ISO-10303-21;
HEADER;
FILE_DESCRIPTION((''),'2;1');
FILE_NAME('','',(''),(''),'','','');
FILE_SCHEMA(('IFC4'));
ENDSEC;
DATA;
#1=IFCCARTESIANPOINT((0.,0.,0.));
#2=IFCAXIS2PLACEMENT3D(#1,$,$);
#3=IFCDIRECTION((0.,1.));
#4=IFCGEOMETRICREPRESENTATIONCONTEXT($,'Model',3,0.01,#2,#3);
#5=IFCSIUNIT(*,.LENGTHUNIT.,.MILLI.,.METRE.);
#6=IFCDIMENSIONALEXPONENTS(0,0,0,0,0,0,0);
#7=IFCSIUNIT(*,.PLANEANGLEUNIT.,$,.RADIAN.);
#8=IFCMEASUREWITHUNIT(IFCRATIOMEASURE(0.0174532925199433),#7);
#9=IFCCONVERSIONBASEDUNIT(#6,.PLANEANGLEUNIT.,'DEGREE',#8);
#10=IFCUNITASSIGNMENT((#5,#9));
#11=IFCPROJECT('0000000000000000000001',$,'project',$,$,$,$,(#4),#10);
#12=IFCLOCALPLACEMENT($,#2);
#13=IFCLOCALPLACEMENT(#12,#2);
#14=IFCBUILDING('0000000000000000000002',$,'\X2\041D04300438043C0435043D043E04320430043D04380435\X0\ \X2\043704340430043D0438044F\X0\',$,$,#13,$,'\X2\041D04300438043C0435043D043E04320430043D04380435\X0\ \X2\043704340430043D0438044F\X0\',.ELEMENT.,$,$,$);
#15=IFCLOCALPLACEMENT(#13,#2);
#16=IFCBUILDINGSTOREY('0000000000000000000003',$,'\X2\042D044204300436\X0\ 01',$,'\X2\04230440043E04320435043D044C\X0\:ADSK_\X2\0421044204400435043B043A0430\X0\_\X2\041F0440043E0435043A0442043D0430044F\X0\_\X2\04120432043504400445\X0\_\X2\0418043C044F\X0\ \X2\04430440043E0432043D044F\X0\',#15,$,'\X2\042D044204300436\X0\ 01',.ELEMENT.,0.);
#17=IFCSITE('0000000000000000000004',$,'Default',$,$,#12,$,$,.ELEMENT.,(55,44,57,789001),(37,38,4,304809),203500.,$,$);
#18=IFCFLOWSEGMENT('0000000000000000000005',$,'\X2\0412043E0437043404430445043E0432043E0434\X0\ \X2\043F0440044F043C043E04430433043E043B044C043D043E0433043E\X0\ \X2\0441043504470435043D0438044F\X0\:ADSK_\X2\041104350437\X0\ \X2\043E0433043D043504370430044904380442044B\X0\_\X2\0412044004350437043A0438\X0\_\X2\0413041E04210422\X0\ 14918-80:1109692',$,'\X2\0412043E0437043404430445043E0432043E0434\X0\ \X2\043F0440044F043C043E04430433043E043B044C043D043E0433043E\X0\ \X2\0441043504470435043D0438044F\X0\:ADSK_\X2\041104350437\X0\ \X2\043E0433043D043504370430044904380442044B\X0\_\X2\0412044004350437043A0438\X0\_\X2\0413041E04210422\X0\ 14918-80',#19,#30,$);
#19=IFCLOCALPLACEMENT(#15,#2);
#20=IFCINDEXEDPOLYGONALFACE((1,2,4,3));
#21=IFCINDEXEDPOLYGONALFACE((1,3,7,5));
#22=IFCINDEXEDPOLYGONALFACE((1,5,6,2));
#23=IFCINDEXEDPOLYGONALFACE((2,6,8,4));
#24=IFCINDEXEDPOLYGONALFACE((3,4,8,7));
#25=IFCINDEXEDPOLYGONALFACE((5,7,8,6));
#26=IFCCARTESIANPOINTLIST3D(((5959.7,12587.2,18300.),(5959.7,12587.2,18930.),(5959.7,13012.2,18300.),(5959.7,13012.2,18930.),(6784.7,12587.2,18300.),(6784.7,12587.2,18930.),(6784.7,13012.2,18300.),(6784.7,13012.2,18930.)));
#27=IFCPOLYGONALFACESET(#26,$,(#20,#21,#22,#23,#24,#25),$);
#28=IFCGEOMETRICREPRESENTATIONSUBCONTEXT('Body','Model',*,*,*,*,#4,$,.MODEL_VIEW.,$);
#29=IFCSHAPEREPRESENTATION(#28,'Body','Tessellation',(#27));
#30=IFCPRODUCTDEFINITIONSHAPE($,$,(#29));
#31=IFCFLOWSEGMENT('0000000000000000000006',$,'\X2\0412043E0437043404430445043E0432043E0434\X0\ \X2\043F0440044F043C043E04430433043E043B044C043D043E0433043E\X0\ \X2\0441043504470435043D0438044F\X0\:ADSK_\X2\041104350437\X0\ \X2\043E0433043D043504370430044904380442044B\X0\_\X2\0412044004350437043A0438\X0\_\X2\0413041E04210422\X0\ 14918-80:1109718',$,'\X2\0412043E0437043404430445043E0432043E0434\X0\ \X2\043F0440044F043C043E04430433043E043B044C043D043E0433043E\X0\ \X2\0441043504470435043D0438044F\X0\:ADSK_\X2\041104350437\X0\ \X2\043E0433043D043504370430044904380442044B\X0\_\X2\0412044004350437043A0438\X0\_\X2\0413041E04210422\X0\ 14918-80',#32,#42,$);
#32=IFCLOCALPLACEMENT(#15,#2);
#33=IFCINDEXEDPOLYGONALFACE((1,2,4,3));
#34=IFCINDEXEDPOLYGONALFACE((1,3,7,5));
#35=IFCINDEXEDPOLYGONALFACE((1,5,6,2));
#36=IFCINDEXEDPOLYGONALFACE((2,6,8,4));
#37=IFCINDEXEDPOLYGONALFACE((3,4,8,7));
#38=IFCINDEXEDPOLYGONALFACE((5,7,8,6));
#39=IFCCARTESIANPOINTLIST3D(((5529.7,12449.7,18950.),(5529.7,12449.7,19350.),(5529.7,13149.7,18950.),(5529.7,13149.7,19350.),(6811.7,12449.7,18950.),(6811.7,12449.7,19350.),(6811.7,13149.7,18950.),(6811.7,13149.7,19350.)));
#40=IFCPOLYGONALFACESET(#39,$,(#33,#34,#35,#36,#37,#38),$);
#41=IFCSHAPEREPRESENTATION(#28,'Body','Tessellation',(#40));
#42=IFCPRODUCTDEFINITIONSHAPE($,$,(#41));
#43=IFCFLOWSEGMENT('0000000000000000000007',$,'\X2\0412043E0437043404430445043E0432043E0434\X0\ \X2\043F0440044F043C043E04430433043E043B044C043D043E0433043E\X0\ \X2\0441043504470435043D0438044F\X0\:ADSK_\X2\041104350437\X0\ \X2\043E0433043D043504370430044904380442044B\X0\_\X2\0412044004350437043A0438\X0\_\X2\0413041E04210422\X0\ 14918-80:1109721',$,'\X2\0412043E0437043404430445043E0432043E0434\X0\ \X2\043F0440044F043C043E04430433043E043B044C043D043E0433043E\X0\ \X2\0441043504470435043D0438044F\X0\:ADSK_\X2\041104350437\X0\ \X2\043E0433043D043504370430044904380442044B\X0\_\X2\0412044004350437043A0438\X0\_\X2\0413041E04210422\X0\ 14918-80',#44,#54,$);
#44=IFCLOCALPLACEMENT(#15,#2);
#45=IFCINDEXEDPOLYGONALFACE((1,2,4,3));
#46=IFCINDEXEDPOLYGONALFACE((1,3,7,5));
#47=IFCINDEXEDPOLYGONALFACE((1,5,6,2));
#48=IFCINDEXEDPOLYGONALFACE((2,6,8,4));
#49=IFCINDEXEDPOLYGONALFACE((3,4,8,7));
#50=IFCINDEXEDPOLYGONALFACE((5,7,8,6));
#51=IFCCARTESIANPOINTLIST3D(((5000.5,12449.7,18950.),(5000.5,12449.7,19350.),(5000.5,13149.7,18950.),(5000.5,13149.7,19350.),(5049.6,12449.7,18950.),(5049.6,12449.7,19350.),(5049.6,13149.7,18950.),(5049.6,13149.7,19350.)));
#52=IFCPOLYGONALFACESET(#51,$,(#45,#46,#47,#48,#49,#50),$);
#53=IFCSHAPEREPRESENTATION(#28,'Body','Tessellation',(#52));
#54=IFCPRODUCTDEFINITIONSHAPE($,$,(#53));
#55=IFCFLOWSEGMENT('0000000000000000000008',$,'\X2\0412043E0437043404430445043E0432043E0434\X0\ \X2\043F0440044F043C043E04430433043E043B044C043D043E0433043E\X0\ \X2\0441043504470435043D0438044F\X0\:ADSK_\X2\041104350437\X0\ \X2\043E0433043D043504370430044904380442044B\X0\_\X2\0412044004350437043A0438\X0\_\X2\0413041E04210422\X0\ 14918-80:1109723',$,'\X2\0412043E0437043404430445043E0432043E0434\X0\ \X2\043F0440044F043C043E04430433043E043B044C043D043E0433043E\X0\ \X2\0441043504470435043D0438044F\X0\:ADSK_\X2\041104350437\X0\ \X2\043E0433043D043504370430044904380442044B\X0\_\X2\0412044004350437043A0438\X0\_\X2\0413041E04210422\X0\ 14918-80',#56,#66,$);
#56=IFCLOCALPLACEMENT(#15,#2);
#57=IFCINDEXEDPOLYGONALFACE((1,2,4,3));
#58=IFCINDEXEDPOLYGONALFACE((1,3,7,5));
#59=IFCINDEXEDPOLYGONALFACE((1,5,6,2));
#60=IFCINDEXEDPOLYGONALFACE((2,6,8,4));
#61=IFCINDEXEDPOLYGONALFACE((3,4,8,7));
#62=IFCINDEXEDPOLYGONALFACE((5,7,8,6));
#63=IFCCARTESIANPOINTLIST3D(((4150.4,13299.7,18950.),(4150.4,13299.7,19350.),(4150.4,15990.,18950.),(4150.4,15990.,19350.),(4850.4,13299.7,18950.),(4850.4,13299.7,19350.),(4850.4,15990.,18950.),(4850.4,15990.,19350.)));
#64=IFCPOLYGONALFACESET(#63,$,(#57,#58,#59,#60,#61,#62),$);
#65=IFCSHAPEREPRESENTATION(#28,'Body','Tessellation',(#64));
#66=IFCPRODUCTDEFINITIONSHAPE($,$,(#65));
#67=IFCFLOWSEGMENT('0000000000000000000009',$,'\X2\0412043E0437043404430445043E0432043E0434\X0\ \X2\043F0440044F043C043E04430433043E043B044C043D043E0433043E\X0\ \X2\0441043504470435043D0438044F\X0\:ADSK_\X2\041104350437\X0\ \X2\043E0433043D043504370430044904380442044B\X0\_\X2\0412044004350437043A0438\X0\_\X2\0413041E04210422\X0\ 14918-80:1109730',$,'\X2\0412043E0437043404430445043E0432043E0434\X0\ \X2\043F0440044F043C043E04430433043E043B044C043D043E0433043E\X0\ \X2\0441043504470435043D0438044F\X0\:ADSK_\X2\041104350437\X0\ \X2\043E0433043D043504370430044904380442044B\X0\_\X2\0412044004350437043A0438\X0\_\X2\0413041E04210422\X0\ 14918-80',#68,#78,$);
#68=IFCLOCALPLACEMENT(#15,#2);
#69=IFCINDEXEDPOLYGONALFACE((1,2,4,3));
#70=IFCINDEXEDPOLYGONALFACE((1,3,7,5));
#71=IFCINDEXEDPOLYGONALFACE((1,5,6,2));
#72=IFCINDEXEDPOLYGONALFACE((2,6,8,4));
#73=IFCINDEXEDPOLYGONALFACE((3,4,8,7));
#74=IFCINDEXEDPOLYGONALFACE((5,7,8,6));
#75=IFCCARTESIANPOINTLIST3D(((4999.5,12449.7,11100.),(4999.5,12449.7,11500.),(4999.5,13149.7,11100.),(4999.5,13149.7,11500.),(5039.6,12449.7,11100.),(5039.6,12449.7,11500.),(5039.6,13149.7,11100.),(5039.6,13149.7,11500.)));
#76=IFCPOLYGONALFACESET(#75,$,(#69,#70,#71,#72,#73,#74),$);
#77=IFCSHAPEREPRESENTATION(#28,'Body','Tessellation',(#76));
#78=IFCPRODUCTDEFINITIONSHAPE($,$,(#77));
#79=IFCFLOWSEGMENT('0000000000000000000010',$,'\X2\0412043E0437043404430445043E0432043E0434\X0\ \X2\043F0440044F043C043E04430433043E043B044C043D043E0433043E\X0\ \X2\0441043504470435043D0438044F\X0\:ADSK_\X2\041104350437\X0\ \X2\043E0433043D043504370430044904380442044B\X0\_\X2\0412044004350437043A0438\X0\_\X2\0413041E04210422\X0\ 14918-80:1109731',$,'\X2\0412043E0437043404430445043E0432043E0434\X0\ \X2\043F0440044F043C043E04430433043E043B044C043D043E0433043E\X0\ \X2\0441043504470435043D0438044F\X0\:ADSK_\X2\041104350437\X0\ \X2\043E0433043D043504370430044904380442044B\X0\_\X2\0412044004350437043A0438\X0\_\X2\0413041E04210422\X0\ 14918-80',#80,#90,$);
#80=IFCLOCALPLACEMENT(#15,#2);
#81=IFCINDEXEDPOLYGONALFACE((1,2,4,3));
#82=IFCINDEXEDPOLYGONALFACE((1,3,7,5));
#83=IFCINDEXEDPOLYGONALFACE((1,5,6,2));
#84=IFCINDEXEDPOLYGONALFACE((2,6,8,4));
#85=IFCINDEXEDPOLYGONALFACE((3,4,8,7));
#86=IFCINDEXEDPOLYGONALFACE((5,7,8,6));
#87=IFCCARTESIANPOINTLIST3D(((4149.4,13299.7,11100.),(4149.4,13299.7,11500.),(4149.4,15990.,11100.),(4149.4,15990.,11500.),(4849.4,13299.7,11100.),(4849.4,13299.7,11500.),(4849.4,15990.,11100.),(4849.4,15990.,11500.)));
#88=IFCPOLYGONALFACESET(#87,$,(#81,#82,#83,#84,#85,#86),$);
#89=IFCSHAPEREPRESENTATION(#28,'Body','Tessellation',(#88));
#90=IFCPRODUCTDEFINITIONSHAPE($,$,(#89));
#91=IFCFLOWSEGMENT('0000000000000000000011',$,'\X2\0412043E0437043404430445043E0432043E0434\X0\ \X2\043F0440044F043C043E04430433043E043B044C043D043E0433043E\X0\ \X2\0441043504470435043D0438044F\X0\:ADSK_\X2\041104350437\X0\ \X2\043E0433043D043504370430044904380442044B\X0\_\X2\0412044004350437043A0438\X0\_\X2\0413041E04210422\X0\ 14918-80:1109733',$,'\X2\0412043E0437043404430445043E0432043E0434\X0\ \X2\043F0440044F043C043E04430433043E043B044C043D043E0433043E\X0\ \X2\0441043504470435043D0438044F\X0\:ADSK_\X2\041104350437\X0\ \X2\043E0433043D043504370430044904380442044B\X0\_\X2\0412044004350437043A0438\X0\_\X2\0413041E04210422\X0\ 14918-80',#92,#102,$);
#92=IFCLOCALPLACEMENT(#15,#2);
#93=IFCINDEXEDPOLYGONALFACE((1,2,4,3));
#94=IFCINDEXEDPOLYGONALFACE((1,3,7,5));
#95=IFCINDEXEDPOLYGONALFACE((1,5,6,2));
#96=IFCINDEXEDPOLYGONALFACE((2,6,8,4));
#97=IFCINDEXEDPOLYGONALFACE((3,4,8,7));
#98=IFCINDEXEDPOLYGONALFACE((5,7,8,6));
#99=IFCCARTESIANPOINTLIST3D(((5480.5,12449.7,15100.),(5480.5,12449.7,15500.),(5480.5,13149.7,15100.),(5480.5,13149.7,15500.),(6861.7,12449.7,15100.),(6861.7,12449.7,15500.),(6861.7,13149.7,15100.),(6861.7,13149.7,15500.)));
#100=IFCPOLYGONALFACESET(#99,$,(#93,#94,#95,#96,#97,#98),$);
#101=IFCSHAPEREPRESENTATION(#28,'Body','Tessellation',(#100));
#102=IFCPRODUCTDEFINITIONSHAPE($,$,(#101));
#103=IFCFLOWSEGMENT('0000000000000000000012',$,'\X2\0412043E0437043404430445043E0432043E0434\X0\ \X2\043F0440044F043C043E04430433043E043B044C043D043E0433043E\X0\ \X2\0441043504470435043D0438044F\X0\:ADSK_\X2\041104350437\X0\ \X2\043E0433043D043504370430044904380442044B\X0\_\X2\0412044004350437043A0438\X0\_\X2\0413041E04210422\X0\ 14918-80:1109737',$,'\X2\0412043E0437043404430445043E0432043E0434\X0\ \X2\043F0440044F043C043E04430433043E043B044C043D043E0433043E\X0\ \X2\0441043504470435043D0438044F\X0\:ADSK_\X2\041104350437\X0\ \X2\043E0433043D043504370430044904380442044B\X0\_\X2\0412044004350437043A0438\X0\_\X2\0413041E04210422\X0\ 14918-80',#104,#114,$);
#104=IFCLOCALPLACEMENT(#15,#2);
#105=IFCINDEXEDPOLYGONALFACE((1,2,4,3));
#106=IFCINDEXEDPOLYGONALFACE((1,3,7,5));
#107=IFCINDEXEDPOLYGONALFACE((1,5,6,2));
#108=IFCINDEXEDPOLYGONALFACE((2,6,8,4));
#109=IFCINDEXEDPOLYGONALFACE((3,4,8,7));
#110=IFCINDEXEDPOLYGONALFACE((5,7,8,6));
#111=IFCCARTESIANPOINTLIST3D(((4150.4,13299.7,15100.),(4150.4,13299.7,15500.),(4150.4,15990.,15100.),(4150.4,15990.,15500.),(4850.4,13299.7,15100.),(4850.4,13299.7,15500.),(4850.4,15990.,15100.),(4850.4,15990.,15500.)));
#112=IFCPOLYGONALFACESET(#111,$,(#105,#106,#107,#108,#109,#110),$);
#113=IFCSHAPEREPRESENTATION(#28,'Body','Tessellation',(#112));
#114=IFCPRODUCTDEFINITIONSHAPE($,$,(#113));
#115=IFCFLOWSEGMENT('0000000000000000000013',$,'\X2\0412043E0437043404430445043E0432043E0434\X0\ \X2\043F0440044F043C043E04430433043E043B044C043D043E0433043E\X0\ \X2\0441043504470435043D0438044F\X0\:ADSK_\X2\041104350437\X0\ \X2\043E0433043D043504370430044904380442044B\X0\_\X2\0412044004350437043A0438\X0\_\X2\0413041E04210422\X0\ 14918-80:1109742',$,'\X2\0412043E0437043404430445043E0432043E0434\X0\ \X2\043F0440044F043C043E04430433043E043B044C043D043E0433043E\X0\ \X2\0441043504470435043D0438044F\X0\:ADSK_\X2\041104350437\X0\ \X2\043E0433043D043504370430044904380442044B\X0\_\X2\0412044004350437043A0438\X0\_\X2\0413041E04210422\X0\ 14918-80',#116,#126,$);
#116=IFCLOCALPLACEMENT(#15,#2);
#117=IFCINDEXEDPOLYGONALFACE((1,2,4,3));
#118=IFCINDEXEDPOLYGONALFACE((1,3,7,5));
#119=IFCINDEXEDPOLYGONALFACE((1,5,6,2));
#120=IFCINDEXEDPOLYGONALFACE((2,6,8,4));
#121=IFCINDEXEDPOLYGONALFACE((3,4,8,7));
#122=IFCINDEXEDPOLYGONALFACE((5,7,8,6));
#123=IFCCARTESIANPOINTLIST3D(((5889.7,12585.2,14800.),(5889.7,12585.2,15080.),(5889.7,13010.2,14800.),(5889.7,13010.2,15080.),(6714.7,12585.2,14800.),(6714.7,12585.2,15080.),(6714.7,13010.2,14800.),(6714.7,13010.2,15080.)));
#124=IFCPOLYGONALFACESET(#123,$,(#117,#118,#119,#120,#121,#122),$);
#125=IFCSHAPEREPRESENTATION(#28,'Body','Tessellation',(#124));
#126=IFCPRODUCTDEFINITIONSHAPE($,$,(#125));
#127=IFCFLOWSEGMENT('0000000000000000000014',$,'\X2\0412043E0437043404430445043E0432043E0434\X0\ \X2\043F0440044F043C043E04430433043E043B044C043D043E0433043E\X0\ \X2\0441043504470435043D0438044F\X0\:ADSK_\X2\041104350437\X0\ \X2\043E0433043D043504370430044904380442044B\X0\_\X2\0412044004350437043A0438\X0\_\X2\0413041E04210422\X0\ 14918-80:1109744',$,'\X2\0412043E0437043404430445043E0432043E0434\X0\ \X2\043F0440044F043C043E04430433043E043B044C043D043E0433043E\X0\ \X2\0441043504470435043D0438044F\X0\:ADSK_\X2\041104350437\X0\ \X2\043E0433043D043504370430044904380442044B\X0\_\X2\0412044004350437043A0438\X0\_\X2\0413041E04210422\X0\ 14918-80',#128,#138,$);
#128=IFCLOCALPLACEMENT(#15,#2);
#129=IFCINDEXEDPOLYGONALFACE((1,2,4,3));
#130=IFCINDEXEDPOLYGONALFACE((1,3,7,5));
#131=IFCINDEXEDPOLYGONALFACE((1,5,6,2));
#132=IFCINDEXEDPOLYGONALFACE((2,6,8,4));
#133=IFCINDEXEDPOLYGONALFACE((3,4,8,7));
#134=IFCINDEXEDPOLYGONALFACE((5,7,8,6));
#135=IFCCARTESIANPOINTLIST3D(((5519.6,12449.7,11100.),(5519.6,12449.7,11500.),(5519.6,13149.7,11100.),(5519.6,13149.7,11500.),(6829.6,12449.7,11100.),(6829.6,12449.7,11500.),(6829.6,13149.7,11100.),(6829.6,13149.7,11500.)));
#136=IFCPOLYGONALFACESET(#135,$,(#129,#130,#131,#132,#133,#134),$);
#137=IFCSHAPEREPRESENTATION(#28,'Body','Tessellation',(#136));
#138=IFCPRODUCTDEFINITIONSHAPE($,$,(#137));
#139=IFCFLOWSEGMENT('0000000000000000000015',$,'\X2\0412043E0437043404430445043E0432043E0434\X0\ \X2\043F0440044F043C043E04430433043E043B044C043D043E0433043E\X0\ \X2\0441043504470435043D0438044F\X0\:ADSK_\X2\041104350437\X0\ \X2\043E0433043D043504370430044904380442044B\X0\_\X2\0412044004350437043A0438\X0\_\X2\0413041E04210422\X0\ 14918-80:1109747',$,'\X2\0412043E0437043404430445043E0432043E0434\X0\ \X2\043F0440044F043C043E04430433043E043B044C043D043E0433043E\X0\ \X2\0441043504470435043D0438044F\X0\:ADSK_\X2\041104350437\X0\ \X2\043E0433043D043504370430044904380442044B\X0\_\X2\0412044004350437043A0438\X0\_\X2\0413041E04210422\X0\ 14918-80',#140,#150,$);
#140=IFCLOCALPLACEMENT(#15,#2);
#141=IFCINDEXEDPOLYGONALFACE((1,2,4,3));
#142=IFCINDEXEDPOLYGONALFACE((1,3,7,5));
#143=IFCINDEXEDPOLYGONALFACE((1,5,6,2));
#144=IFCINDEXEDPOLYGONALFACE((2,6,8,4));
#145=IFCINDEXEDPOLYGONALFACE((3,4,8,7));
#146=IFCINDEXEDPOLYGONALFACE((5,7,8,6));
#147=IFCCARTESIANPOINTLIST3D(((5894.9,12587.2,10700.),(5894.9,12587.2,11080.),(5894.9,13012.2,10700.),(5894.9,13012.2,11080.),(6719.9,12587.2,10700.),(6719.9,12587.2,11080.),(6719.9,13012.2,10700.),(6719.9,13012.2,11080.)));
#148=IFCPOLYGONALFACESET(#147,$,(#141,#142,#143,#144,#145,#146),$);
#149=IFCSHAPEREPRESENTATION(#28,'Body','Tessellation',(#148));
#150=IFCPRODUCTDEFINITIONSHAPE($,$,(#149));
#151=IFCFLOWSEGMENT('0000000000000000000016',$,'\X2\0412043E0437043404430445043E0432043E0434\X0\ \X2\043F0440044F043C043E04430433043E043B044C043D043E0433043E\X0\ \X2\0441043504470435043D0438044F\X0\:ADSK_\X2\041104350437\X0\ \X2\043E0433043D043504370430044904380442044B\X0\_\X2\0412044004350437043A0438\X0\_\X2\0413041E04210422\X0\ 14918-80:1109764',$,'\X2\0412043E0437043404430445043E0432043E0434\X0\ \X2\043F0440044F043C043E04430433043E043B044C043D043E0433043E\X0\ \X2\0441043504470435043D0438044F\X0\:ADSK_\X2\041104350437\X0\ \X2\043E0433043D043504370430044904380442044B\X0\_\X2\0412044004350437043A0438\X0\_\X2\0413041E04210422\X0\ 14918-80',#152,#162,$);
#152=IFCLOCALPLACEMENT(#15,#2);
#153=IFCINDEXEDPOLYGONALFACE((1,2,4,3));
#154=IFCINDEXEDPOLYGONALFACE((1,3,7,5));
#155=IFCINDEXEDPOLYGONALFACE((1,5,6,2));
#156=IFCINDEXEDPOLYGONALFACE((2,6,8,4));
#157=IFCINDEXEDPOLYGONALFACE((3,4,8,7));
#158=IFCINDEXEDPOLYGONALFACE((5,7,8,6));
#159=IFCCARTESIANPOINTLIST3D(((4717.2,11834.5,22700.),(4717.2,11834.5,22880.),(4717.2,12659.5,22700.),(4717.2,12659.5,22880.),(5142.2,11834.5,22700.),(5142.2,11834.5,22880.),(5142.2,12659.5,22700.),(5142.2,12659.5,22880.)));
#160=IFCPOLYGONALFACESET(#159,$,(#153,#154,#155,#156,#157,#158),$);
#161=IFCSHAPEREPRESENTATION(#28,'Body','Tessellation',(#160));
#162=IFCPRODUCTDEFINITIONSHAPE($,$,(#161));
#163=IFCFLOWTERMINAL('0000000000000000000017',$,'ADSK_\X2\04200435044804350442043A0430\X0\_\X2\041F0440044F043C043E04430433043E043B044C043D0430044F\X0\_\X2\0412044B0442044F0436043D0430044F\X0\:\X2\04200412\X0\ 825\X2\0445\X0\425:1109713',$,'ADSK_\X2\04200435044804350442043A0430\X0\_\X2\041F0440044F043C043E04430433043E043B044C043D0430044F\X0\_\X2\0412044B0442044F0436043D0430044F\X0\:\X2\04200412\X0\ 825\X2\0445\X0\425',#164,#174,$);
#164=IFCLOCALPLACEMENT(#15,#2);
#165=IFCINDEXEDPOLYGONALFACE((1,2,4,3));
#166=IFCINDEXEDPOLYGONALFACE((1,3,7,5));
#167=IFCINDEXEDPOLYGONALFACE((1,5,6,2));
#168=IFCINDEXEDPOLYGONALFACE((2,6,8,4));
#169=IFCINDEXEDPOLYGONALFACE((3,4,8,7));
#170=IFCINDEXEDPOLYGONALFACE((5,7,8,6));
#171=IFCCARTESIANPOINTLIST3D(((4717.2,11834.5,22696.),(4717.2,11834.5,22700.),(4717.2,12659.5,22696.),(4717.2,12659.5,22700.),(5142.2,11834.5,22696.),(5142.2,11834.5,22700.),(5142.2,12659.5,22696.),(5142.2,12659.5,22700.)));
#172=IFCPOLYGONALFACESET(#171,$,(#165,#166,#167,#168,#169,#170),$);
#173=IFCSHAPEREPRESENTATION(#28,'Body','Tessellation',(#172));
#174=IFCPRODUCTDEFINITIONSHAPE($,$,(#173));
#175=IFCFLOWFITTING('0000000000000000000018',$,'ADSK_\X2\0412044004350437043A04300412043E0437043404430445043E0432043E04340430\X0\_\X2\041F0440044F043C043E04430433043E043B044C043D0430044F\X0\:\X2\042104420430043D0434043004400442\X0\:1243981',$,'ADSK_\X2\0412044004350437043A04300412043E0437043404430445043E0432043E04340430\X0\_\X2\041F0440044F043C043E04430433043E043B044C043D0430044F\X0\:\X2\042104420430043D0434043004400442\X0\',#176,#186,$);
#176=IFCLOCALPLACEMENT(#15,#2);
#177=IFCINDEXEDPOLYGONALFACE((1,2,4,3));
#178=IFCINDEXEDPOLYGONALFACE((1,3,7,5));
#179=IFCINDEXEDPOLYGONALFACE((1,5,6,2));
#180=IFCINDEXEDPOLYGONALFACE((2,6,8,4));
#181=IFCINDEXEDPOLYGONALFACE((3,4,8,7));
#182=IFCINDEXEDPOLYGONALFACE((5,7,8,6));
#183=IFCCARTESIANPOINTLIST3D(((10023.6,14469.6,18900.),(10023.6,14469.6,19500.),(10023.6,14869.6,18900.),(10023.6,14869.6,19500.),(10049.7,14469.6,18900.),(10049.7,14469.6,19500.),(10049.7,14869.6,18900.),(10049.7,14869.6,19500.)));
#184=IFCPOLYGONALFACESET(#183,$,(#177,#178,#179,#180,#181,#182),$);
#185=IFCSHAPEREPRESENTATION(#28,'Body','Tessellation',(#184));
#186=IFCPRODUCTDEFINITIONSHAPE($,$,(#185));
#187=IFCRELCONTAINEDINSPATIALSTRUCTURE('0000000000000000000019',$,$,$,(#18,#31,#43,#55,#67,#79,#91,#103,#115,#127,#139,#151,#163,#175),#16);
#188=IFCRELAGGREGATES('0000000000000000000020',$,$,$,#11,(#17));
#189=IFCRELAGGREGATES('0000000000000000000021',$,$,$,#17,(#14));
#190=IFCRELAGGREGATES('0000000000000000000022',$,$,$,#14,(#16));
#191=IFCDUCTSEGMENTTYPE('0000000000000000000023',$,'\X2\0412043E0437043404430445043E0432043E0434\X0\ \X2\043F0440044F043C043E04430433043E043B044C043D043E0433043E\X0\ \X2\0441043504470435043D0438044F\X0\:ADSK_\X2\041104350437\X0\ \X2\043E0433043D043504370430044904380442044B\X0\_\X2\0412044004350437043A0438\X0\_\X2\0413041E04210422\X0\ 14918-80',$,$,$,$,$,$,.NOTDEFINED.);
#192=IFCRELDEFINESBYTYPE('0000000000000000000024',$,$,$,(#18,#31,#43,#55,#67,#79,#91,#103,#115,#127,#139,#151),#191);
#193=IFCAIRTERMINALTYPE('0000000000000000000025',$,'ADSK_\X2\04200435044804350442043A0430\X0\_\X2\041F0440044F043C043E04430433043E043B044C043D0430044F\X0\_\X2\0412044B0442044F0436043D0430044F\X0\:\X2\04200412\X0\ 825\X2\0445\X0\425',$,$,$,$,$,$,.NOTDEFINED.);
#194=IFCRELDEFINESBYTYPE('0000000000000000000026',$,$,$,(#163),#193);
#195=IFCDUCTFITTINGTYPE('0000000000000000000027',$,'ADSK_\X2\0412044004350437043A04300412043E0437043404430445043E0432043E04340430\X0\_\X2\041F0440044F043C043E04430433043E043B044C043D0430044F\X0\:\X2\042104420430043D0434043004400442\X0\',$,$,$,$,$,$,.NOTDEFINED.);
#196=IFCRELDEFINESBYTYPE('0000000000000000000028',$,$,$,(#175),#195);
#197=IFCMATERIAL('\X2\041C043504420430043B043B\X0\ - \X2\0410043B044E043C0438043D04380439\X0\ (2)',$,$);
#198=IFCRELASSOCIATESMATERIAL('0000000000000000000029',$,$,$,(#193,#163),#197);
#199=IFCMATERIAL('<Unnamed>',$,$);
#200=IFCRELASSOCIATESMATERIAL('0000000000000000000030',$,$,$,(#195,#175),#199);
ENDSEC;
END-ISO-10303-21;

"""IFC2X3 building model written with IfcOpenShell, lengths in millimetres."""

from ifc_helpers import new_model, entity, si_unit, converted_unit, direction, frame, origin, origin_2d_with_axis, place, context, subcontext, project, spatial, rectangle, extrude, source, transform, mapped, material, type_object, type_shapes, element, save


model = new_model("IFC2X3")

# Units and contexts
model_context = context("Model", 3, precision=0.01, world=origin(), true_north=direction((0.0, 1.0)))
body_context = subcontext(model_context, "Body", "Model", "MODEL_VIEW")
ifc_project = project(units=[si_unit("LENGTHUNIT", "METRE", prefix="MILLI"), converted_unit("PLANEANGLEUNIT", "DEGREE", entity("IfcRatioMeasure", 0.0174532925199433), si_unit("PLANEANGLEUNIT", "RADIAN"), dimensions=[0, 0, 0, 0, 0, 0, 0])], contexts=[model_context])

# Site, building, storey
site_placement = place(None, origin())
site = spatial("IfcSite", under=ifc_project, at=site_placement, Name="Default", CompositionType="ELEMENT", RefLatitude=(55, 44, 57, 789001), RefLongitude=(37, 38, 4, 304809), RefElevation=203500.0)
building_placement = place(site_placement, origin())
building = spatial("IfcBuilding", under=site, at=building_placement, Name="Наименование здания", LongName="Наименование здания", CompositionType="ELEMENT")
storey_placement = place(building_placement, origin())
storey = spatial("IfcBuildingStorey", under=building, at=storey_placement, Name="Этаж 01", ObjectType="Уровень:ADSK_Стрелка_Проектная_Вверх_Имя уровня", LongName="Этаж 01", CompositionType="ELEMENT", Elevation=0.0)

# Flow segments
duct_segment_type_1 = type_object("IfcDuctSegmentType", Name="Воздуховод прямоугольного сечения:ADSK_Без огнезащиты_Врезки_ГОСТ 14918-80", PredefinedType="NOTDEFINED")
flow_segment_1_placement = place(storey_placement, frame((5959.7, 12587.2, 18300.0)))
element("IfcFlowSegment", 1, at=flow_segment_1_placement, inside=storey, type_object=duct_segment_type_1, Name="Воздуховод прямоугольного сечения:ADSK_Без огнезащиты_Врезки_ГОСТ 14918-80:1109692", ObjectType="Воздуховод прямоугольного сечения:ADSK_Без огнезащиты_Врезки_ГОСТ 14918-80", context=body_context, shape_type="SweptSolid", body=[
    extrude(rectangle(XDim=825.0, YDim=425.0, at=origin_2d_with_axis()), frame((412.5, 212.5, 0.0), z_axis=(0.0, 0.0, 1.0), x_axis=(-1.0, 0.0, 0.0)), (0.0, 0.0, 1.0), 630.0),
])
flow_segment_2_placement = place(storey_placement, frame((5529.6, 12449.7, 18950.0)))
element("IfcFlowSegment", 2, at=flow_segment_2_placement, inside=storey, type_object=duct_segment_type_1, Name="Воздуховод прямоугольного сечения:ADSK_Без огнезащиты_Врезки_ГОСТ 14918-80:1109718", ObjectType="Воздуховод прямоугольного сечения:ADSK_Без огнезащиты_Врезки_ГОСТ 14918-80", context=body_context, shape_type="SweptSolid", body=[
    extrude(rectangle(XDim=1282.1, YDim=700.0, at=origin_2d_with_axis()), frame((641.0, 350.0, 0.0)), (0.0, 0.0, 1.0), 400.0),
])
flow_segment_3_placement = place(storey_placement, frame((5000.4, 12449.7, 18950.0)))
element("IfcFlowSegment", 3, at=flow_segment_3_placement, inside=storey, type_object=duct_segment_type_1, Name="Воздуховод прямоугольного сечения:ADSK_Без огнезащиты_Врезки_ГОСТ 14918-80:1109721", ObjectType="Воздуховод прямоугольного сечения:ADSK_Без огнезащиты_Врезки_ГОСТ 14918-80", context=body_context, shape_type="SweptSolid", body=[
    extrude(rectangle(XDim=49.2, YDim=700.0, at=origin_2d_with_axis()), frame((24.6, 350.0, 0.0)), (0.0, 0.0, 1.0), 400.0),
])
flow_segment_4_placement = place(storey_placement, frame((4150.4, 13299.7, 18950.0)))
element("IfcFlowSegment", 4, at=flow_segment_4_placement, inside=storey, type_object=duct_segment_type_1, Name="Воздуховод прямоугольного сечения:ADSK_Без огнезащиты_Врезки_ГОСТ 14918-80:1109723", ObjectType="Воздуховод прямоугольного сечения:ADSK_Без огнезащиты_Врезки_ГОСТ 14918-80", context=body_context, shape_type="SweptSolid", body=[
    extrude(rectangle(XDim=2690.3, YDim=700.0, at=origin_2d_with_axis()), frame((350.0, 1345.2, 0.0), z_axis=(0.0, 0.0, 1.0), x_axis=(0.0, 1.0, 0.0)), (0.0, 0.0, 1.0), 400.0),
])
flow_segment_5_placement = place(storey_placement, frame((4999.4, 12449.7, 11100.0)))
element("IfcFlowSegment", 5, at=flow_segment_5_placement, inside=storey, type_object=duct_segment_type_1, Name="Воздуховод прямоугольного сечения:ADSK_Без огнезащиты_Врезки_ГОСТ 14918-80:1109730", ObjectType="Воздуховод прямоугольного сечения:ADSK_Без огнезащиты_Врезки_ГОСТ 14918-80", context=body_context, shape_type="SweptSolid", body=[
    extrude(rectangle(XDim=40.2, YDim=700.0, at=origin_2d_with_axis()), frame((20.1, 350.0, 0.0)), (0.0, 0.0, 1.0), 400.0),
])
flow_segment_6_placement = place(storey_placement, frame((4149.4, 13299.7, 11100.0)))
element("IfcFlowSegment", 6, at=flow_segment_6_placement, inside=storey, type_object=duct_segment_type_1, Name="Воздуховод прямоугольного сечения:ADSK_Без огнезащиты_Врезки_ГОСТ 14918-80:1109731", ObjectType="Воздуховод прямоугольного сечения:ADSK_Без огнезащиты_Врезки_ГОСТ 14918-80", context=body_context, shape_type="SweptSolid", body=[
    extrude(rectangle(XDim=2690.3, YDim=700.0, at=origin_2d_with_axis()), frame((350.0, 1345.2, 0.0), z_axis=(0.0, 0.0, 1.0), x_axis=(0.0, 1.0, 0.0)), (0.0, 0.0, 1.0), 400.0),
])
flow_segment_7_placement = place(storey_placement, frame((5480.4, 12449.7, 15100.0)))
element("IfcFlowSegment", 7, at=flow_segment_7_placement, inside=storey, type_object=duct_segment_type_1, Name="Воздуховод прямоугольного сечения:ADSK_Без огнезащиты_Врезки_ГОСТ 14918-80:1109733", ObjectType="Воздуховод прямоугольного сечения:ADSK_Без огнезащиты_Врезки_ГОСТ 14918-80", context=body_context, shape_type="SweptSolid", body=[
    extrude(rectangle(XDim=1381.3, YDim=700.0, at=origin_2d_with_axis()), frame((690.6, 350.0, 0.0)), (0.0, 0.0, 1.0), 400.0),
])
flow_segment_8_placement = place(storey_placement, frame((4150.4, 13299.7, 15100.0)))
element("IfcFlowSegment", 8, at=flow_segment_8_placement, inside=storey, type_object=duct_segment_type_1, Name="Воздуховод прямоугольного сечения:ADSK_Без огнезащиты_Врезки_ГОСТ 14918-80:1109737", ObjectType="Воздуховод прямоугольного сечения:ADSK_Без огнезащиты_Врезки_ГОСТ 14918-80", context=body_context, shape_type="SweptSolid", body=[
    extrude(rectangle(XDim=2690.3, YDim=700.0, at=origin_2d_with_axis()), frame((350.0, 1345.2, 0.0), z_axis=(0.0, 0.0, 1.0), x_axis=(0.0, 1.0, 0.0)), (0.0, 0.0, 1.0), 400.0),
])
flow_segment_9_placement = place(storey_placement, frame((5889.7, 12585.2, 14800.0)))
element("IfcFlowSegment", 9, at=flow_segment_9_placement, inside=storey, type_object=duct_segment_type_1, Name="Воздуховод прямоугольного сечения:ADSK_Без огнезащиты_Врезки_ГОСТ 14918-80:1109742", ObjectType="Воздуховод прямоугольного сечения:ADSK_Без огнезащиты_Врезки_ГОСТ 14918-80", context=body_context, shape_type="SweptSolid", body=[
    extrude(rectangle(XDim=825.0, YDim=425.0, at=origin_2d_with_axis()), frame((412.5, 212.5, 0.0)), (0.0, 0.0, 1.0), 280.0),
])
flow_segment_10_placement = place(storey_placement, frame((5519.6, 12449.7, 11100.0)))
element("IfcFlowSegment", 10, at=flow_segment_10_placement, inside=storey, type_object=duct_segment_type_1, Name="Воздуховод прямоугольного сечения:ADSK_Без огнезащиты_Врезки_ГОСТ 14918-80:1109744", ObjectType="Воздуховод прямоугольного сечения:ADSK_Без огнезащиты_Врезки_ГОСТ 14918-80", context=body_context, shape_type="SweptSolid", body=[
    extrude(rectangle(XDim=1310.0, YDim=700.0, at=origin_2d_with_axis()), frame((655.0, 350.0, 0.0)), (0.0, 0.0, 1.0), 400.0),
])
flow_segment_11_placement = place(storey_placement, frame((5894.9, 12587.2, 10700.0)))
element("IfcFlowSegment", 11, at=flow_segment_11_placement, inside=storey, type_object=duct_segment_type_1, Name="Воздуховод прямоугольного сечения:ADSK_Без огнезащиты_Врезки_ГОСТ 14918-80:1109747", ObjectType="Воздуховод прямоугольного сечения:ADSK_Без огнезащиты_Врезки_ГОСТ 14918-80", context=body_context, shape_type="SweptSolid", body=[
    extrude(rectangle(XDim=825.0, YDim=425.0, at=origin_2d_with_axis()), frame((412.5, 212.5, 0.0), z_axis=(0.0, 0.0, 1.0), x_axis=(-1.0, 0.0, 0.0)), (0.0, 0.0, 1.0), 380.0),
])
flow_segment_12_placement = place(storey_placement, frame((4717.2, 11834.5, 22700.0)))
element("IfcFlowSegment", 12, at=flow_segment_12_placement, inside=storey, type_object=duct_segment_type_1, Name="Воздуховод прямоугольного сечения:ADSK_Без огнезащиты_Врезки_ГОСТ 14918-80:1109764", ObjectType="Воздуховод прямоугольного сечения:ADSK_Без огнезащиты_Врезки_ГОСТ 14918-80", context=body_context, shape_type="SweptSolid", body=[
    extrude(rectangle(XDim=825.0, YDim=425.0, at=origin_2d_with_axis()), frame((212.5, 412.5, 0.0), z_axis=(0.0, 0.0, 1.0), x_axis=(0.0, 1.0, 0.0)), (0.0, 0.0, 1.0), 180.0),
])

# Flow terminal
ifc_material_1 = material(Name="Металл - Алюминий (2)")
air_terminal_type = type_object("IfcAirTerminalType", Name="ADSK_Решетка_Прямоугольная_Вытяжная:РВ 825х425", PredefinedType="NOTDEFINED", material=ifc_material_1)
shared_shape_1 = source(origin(), body_context, "Body", "SweptSolid", [
    extrude(rectangle(XDim=4.0, YDim=825.0, at=origin_2d_with_axis()), frame((0.0, -2.0, -212.5), z_axis=(0.0, 0.0, 1.0), x_axis=(0.0, 1.0, 0.0)), (0.0, 0.0, 1.0), 425.0),
])
type_shapes(air_terminal_type, [shared_shape_1])
flow_terminal_placement = place(storey_placement, frame((4929.7, 12247.0, 22700.0), z_axis=(1.0, 0.0, 0.0), x_axis=(0.0, 1.0, 0.0)))
element("IfcFlowTerminal", 13, at=flow_terminal_placement, inside=storey, type_object=air_terminal_type, material=ifc_material_1, Name="ADSK_Решетка_Прямоугольная_Вытяжная:РВ 825х425:1109713", ObjectType="ADSK_Решетка_Прямоугольная_Вытяжная:РВ 825х425", context=body_context, shape_type="MappedRepresentation", body=[
    mapped(shared_shape_1, transform((0.0, 0.0, 0.0), scale=1.0)),
])

# Flow fitting
ifc_material_2 = material(Name="<Unnamed>")
duct_fitting_type_1 = type_object("IfcDuctFittingType", Name="ADSK_ВрезкаВоздуховода_Прямоугольная:Стандарт", PredefinedType="NOTDEFINED", material=ifc_material_2)
shared_shape_2 = source(origin(), body_context, "Body", "SweptSolid", [
    extrude(rectangle(XDim=600.0, YDim=26.1, at=origin_2d_with_axis()), frame((7.0, 0.0, -200.0), z_axis=(0.0, 0.0, 1.0), x_axis=(0.0, -1.0, 0.0)), (0.0, 0.0, 1.0), 400.0),
])
type_shapes(duct_fitting_type_1, [shared_shape_2])
flow_fitting_1_placement = place(storey_placement, frame((10029.7, 14669.6, 19200.0), z_axis=(0.0, -1.0, 0.0), x_axis=(1.0, 0.0, 0.0)))
element("IfcFlowFitting", 14, at=flow_fitting_1_placement, inside=storey, type_object=duct_fitting_type_1, material=ifc_material_2, Name="ADSK_ВрезкаВоздуховода_Прямоугольная:Стандарт:1243981", ObjectType="ADSK_ВрезкаВоздуховода_Прямоугольная:Стандарт", context=body_context, shape_type="MappedRepresentation", body=[
    mapped(shared_shape_2, transform((0.0, 0.0, 0.0), scale=1.0)),
])

save(model, "model.ifc")
